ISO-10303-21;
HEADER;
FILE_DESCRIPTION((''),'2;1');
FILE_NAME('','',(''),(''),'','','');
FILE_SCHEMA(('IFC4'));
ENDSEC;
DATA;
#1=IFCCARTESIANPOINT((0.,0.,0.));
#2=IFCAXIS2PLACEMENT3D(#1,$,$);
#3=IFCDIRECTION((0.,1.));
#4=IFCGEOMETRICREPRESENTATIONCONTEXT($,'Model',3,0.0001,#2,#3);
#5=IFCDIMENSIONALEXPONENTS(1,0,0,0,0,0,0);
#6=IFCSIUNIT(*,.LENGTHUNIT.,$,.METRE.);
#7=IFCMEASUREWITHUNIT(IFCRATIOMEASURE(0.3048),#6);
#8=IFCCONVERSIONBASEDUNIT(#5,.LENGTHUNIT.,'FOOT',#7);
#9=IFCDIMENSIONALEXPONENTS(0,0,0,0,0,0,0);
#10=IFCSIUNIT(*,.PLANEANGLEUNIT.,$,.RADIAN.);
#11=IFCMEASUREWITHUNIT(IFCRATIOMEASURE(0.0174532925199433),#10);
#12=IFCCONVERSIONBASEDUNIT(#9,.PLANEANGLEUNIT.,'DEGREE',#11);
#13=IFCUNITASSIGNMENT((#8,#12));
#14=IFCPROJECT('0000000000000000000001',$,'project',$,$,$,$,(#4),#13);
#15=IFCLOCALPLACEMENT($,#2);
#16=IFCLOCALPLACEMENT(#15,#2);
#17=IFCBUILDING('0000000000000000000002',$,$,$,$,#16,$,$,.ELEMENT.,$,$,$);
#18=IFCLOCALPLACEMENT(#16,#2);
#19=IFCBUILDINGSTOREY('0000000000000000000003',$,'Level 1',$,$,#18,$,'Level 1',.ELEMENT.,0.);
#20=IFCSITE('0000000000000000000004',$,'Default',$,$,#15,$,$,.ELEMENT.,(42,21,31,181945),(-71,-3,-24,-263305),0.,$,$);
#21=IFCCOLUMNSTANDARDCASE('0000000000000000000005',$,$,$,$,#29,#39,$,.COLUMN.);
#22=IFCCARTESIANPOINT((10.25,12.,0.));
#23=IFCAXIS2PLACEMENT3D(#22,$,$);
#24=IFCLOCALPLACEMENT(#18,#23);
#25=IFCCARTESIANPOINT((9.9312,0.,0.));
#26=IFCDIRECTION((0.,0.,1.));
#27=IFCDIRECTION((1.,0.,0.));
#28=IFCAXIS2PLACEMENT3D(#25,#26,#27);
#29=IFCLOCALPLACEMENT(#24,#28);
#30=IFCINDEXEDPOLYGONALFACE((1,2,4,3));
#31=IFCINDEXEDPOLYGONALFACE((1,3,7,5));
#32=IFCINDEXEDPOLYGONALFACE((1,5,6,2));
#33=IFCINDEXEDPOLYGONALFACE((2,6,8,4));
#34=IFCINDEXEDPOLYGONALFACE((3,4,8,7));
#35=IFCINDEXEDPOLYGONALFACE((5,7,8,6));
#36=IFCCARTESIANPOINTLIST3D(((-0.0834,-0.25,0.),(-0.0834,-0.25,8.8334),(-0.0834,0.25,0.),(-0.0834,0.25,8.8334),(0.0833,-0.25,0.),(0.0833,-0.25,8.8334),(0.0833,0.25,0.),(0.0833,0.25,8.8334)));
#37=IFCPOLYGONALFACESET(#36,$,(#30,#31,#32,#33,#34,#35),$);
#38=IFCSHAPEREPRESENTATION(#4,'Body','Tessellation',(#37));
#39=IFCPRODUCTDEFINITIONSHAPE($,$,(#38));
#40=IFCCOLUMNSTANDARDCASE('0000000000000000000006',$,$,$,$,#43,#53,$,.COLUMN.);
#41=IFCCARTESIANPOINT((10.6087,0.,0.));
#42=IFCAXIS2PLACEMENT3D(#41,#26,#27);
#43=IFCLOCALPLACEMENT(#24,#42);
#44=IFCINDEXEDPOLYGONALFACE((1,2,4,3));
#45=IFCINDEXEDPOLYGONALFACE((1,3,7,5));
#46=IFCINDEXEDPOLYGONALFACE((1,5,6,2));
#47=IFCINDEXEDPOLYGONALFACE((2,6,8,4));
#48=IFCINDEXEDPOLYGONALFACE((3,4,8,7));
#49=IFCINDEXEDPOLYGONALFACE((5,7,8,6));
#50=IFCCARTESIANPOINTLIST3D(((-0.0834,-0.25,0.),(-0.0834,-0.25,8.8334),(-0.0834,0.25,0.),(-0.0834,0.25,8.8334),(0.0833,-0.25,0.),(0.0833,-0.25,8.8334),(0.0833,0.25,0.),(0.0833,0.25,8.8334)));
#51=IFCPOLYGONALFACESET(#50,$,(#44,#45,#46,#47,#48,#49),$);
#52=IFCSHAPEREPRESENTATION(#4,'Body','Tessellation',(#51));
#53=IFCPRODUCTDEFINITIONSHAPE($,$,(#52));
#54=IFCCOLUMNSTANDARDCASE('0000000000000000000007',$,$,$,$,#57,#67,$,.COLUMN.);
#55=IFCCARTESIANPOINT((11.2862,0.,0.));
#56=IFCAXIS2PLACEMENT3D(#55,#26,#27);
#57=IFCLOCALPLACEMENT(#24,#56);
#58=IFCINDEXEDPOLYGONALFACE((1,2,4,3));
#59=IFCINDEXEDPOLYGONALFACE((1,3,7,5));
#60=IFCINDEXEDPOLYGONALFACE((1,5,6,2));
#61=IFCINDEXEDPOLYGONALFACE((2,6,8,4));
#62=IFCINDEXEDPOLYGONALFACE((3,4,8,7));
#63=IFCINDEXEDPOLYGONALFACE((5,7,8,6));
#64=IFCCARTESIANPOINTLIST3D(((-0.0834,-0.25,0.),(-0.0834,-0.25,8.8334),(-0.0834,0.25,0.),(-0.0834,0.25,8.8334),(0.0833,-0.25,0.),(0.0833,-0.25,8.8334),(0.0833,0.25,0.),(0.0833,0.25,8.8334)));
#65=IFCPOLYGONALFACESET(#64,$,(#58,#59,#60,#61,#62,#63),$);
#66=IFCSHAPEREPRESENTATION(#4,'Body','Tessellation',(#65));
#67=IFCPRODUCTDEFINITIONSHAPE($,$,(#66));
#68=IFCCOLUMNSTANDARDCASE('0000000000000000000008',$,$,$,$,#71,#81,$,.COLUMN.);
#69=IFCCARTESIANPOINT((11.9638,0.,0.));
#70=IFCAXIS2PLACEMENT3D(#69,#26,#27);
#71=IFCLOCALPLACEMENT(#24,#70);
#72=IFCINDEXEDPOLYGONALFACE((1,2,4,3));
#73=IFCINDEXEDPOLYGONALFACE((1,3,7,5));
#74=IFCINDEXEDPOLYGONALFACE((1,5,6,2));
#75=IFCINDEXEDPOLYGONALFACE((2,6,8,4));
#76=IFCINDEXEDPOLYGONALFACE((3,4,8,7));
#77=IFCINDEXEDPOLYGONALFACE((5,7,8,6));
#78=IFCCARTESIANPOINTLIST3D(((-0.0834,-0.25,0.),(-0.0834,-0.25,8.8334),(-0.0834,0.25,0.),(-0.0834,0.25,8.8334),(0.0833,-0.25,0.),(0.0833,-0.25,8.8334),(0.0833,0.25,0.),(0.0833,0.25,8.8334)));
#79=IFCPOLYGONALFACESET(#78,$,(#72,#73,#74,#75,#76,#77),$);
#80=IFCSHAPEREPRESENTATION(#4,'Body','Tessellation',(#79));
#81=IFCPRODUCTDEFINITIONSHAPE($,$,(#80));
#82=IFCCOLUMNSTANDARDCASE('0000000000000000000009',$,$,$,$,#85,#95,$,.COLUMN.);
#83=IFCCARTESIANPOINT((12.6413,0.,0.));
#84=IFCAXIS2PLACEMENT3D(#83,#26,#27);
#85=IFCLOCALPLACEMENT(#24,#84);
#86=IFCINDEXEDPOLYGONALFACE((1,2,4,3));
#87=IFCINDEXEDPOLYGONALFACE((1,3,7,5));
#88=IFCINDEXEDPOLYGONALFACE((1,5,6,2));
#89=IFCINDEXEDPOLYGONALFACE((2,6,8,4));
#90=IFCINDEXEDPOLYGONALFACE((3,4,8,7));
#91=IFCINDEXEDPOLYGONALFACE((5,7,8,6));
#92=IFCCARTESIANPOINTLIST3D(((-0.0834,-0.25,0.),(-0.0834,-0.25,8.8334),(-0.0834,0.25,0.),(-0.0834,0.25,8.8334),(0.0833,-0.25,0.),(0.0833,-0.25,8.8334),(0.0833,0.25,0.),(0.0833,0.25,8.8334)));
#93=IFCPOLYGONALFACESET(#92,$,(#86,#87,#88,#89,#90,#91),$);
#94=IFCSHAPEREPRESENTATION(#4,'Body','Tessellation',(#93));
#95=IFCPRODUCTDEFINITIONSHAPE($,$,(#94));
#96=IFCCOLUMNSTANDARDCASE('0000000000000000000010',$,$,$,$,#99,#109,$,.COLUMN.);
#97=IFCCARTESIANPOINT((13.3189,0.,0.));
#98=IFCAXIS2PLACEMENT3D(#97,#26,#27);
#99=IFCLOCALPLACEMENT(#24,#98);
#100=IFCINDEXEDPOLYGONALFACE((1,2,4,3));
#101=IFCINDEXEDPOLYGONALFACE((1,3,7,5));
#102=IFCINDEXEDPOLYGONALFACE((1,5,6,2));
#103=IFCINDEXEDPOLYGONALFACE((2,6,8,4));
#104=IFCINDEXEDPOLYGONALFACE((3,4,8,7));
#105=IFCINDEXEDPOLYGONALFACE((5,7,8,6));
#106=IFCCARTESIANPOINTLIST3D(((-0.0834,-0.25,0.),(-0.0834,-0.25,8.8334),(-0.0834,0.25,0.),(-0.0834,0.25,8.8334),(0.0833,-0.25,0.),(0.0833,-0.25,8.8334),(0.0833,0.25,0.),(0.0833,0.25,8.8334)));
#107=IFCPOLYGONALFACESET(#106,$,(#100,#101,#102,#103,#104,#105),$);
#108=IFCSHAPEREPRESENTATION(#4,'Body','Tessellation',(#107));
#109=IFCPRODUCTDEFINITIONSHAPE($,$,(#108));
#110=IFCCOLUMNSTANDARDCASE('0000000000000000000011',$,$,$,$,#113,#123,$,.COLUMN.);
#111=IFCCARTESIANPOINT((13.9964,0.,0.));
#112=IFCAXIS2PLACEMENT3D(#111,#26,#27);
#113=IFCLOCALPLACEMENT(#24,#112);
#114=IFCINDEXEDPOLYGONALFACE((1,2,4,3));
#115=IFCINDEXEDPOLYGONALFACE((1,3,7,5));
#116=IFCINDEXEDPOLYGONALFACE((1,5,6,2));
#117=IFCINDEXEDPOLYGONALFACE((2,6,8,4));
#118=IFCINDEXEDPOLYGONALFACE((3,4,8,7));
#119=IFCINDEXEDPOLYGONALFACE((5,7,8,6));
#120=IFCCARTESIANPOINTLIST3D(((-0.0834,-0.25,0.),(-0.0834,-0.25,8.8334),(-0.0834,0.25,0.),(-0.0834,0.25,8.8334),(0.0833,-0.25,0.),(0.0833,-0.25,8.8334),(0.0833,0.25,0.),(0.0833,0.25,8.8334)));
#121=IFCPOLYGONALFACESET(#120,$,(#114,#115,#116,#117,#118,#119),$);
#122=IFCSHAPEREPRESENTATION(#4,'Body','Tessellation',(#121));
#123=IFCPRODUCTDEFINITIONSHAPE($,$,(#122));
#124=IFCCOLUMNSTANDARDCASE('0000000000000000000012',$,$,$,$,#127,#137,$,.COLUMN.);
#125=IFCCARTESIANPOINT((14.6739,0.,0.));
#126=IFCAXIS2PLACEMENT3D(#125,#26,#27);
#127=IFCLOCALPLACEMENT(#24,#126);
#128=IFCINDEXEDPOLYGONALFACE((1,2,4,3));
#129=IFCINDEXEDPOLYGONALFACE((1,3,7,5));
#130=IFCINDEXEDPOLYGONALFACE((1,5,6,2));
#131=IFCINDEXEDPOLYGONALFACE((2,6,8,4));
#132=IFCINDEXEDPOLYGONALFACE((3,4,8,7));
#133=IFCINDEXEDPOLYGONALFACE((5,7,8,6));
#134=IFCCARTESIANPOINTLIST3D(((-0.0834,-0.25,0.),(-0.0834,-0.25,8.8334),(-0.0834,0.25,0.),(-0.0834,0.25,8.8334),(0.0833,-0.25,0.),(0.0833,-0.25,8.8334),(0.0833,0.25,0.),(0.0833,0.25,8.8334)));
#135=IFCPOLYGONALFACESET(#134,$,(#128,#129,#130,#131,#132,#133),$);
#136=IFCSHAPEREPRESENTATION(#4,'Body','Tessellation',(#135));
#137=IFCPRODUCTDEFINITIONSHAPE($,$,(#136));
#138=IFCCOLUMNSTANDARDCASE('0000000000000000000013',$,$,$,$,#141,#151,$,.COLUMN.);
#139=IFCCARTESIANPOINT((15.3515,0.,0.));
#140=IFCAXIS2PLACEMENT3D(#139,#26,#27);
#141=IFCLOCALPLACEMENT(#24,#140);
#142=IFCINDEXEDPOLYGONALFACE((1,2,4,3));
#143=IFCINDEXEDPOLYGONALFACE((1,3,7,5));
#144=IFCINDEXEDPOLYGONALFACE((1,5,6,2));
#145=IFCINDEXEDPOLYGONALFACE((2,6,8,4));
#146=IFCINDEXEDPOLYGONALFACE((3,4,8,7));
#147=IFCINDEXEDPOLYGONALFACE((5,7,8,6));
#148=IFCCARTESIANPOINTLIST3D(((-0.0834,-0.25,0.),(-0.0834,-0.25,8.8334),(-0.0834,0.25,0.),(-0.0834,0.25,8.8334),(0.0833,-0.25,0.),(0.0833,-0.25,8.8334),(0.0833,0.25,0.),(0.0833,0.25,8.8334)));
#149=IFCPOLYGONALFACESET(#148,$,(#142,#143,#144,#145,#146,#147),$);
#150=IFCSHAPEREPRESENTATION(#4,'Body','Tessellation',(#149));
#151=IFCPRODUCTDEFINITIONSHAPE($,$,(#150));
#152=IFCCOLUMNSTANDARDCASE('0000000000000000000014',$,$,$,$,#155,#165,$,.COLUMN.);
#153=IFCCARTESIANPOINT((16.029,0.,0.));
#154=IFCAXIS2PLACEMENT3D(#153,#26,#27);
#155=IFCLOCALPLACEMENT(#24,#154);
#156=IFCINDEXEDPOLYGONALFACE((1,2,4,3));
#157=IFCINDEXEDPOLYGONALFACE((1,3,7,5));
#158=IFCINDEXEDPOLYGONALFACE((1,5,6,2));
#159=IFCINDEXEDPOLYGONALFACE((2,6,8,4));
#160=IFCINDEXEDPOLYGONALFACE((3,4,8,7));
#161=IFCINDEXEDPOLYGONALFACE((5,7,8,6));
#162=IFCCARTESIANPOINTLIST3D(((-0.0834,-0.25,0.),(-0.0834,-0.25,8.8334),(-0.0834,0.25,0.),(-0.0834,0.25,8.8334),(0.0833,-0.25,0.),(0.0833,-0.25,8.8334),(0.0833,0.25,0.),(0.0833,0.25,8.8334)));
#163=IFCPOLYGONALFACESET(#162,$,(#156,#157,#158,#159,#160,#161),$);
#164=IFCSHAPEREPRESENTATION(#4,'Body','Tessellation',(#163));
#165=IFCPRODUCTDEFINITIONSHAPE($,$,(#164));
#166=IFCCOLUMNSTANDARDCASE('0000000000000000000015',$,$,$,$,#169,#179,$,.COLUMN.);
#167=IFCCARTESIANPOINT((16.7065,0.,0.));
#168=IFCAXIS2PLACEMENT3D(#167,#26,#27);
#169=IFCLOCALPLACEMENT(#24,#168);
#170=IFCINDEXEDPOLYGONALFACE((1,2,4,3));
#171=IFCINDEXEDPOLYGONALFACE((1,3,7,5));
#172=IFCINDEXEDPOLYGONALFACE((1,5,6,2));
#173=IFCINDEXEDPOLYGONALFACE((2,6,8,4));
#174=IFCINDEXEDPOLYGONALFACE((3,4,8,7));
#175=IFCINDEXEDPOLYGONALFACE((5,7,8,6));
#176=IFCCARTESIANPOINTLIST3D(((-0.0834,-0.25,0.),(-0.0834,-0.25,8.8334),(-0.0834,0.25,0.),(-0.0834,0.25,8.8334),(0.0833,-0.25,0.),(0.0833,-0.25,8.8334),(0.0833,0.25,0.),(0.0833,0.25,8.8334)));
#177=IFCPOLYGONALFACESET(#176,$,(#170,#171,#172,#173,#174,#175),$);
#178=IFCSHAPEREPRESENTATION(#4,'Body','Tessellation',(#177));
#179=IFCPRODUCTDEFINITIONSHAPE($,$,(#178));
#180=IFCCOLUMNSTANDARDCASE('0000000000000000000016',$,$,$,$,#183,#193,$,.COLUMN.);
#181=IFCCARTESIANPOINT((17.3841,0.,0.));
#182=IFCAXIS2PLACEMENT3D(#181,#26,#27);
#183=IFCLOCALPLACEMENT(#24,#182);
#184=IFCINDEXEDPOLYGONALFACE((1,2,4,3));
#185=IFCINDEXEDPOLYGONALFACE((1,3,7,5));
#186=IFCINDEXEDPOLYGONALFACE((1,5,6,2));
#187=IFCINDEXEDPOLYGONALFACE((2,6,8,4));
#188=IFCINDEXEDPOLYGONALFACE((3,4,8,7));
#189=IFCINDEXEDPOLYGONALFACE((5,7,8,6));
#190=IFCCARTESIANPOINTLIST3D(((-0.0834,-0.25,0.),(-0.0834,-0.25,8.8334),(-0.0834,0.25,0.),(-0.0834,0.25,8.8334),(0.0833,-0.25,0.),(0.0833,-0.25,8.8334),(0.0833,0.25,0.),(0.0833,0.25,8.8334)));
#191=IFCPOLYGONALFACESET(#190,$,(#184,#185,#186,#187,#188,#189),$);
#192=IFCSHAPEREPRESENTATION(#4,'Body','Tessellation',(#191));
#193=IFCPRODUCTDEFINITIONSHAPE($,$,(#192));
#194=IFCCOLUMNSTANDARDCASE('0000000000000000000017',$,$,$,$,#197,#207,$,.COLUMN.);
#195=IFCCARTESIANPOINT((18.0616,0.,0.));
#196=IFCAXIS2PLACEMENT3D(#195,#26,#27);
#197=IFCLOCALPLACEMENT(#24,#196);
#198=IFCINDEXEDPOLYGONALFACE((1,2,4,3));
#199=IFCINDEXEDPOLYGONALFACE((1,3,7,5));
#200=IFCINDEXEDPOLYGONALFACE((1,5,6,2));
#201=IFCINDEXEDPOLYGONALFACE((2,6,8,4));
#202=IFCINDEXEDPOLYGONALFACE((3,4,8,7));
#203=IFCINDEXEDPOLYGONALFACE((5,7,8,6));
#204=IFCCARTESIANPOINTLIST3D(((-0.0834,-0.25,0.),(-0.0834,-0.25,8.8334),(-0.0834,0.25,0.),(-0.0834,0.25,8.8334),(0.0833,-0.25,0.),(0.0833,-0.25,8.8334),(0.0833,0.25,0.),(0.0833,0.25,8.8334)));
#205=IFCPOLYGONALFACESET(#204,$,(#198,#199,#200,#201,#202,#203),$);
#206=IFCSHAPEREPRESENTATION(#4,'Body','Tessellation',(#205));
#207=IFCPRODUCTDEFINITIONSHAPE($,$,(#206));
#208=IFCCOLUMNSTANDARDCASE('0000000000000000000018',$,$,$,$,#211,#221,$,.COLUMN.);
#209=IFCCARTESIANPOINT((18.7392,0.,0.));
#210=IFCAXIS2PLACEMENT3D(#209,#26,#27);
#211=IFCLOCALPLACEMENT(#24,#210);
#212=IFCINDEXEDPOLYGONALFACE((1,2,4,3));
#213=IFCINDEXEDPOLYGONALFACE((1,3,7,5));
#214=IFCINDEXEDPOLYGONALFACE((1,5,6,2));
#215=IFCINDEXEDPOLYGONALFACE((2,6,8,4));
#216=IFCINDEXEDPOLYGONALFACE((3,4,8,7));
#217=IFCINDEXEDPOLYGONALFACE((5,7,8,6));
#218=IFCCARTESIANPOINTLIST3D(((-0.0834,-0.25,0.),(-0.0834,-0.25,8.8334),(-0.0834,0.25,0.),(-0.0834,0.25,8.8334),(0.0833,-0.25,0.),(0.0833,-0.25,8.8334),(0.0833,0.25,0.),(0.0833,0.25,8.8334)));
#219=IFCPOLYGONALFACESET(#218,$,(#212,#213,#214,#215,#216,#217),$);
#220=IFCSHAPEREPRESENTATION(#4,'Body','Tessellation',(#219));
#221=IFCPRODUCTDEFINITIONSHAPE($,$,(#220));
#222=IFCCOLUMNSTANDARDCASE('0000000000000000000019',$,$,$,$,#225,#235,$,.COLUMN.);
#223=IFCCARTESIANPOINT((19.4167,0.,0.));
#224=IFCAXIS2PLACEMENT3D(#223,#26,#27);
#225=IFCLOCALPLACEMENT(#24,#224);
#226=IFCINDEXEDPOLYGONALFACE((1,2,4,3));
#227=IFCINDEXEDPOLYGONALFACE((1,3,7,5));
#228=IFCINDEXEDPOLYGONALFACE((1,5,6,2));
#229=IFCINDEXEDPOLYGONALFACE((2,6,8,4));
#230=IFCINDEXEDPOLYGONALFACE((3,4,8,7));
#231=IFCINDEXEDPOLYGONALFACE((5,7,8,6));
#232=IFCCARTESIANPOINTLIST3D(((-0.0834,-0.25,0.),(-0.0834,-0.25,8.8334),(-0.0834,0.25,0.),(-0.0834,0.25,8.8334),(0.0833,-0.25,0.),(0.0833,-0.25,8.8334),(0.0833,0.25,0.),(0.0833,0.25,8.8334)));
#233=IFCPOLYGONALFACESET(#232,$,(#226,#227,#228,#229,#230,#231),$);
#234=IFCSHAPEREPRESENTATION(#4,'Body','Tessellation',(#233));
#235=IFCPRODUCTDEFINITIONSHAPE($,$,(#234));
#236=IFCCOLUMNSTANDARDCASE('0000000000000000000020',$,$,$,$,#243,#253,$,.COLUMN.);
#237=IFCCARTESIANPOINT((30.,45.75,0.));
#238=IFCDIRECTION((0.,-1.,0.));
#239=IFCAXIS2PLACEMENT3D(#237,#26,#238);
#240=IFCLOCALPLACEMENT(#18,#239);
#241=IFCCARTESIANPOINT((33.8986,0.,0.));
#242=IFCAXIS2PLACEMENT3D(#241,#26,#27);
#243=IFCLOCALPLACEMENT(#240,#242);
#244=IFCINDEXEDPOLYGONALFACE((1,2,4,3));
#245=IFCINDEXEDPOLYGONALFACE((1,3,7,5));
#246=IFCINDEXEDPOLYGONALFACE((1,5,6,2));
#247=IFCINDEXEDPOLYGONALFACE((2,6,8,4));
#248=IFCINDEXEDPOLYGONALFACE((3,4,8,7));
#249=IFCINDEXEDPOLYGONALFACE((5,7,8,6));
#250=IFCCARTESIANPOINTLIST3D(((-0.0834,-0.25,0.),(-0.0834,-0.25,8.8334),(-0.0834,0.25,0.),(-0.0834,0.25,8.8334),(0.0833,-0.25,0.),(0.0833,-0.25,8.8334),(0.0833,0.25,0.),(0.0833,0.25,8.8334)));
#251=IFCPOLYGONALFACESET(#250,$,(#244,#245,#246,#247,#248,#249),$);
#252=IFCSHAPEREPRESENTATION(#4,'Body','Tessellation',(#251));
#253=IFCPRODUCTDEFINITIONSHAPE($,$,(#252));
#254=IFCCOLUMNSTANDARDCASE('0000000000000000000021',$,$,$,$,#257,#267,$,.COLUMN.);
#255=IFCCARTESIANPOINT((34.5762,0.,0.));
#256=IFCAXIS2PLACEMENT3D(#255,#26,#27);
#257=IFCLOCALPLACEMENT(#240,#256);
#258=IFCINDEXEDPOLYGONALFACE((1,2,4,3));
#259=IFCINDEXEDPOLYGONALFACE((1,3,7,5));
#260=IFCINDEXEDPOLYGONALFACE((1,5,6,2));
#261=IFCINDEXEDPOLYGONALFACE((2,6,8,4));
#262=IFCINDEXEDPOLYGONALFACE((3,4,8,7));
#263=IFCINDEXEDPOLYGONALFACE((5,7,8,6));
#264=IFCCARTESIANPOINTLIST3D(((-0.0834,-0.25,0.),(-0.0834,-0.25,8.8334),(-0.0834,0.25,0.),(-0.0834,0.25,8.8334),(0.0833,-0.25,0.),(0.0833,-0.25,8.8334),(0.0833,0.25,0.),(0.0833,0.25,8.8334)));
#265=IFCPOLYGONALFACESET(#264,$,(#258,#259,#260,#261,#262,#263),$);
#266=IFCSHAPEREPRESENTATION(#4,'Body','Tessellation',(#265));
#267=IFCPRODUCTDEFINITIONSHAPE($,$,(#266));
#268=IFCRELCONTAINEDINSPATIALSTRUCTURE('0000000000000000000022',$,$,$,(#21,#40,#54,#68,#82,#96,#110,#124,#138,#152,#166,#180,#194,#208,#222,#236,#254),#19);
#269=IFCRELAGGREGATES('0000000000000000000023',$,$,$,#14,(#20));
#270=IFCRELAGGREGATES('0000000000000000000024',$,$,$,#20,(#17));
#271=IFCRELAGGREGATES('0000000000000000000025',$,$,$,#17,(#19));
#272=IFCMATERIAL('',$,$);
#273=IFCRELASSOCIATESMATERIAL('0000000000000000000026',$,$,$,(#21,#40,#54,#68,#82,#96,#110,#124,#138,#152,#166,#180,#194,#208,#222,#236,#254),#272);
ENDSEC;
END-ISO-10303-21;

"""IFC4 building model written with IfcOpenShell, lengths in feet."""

from ifc_helpers import new_model, entity, si_unit, converted_unit, direction, frame, origin, place, context, project, spatial, rectangle, extrude, material, element, save


model = new_model("IFC4")

# Units and contexts
model_context = context("Model", 3, precision=0.0001, world=origin(), true_north=direction((0.0, 1.0)))
ifc_project = project(units=[converted_unit("LENGTHUNIT", "FOOT", entity("IfcRatioMeasure", 0.3048), si_unit("LENGTHUNIT", "METRE"), dimensions=[1, 0, 0, 0, 0, 0, 0]), converted_unit("PLANEANGLEUNIT", "DEGREE", entity("IfcRatioMeasure", 0.0174532925199433), si_unit("PLANEANGLEUNIT", "RADIAN"), dimensions=[0, 0, 0, 0, 0, 0, 0])], contexts=[model_context])

# Site, building, storey
site_placement = place(None, origin())
site = spatial("IfcSite", under=ifc_project, at=site_placement, Name="Default", CompositionType="ELEMENT", RefLatitude=(42, 21, 31, 181945), RefLongitude=(-71, -3, -24, -263305), RefElevation=0.0)
building_placement = place(site_placement, origin())
building = spatial("IfcBuilding", under=site, at=building_placement, CompositionType="ELEMENT")
storey_placement = place(building_placement, origin())
storey = spatial("IfcBuildingStorey", under=building, at=storey_placement, Name="Level 1", LongName="Level 1", CompositionType="ELEMENT", Elevation=0.0)

# Columns
ifc_material_1 = material(Name="")
placement_1 = place(storey_placement, frame((10.25, 12.0, 0.0)))
for number, where, z_axis, x_axis in (
    (1, (9.9312, 0.0, 0.0), (0.0, 0.0, 1.0), (1.0, 0.0, 0.0)),
    (2, (10.6087, 0.0, 0.0), (0.0, 0.0, 1.0), (1.0, 0.0, 0.0)),
    (3, (11.2862, 0.0, 0.0), (0.0, 0.0, 1.0), (1.0, 0.0, 0.0)),
    (4, (11.9638, 0.0, 0.0), (0.0, 0.0, 1.0), (1.0, 0.0, 0.0)),
    (5, (12.6413, 0.0, 0.0), (0.0, 0.0, 1.0), (1.0, 0.0, 0.0)),
    (6, (13.3189, 0.0, 0.0), (0.0, 0.0, 1.0), (1.0, 0.0, 0.0)),
    (7, (13.9964, 0.0, 0.0), (0.0, 0.0, 1.0), (1.0, 0.0, 0.0)),
    (8, (14.6739, 0.0, 0.0), (0.0, 0.0, 1.0), (1.0, 0.0, 0.0)),
    (9, (15.3515, 0.0, 0.0), (0.0, 0.0, 1.0), (1.0, 0.0, 0.0)),
    (10, (16.029, 0.0, 0.0), (0.0, 0.0, 1.0), (1.0, 0.0, 0.0)),
    (11, (16.7065, 0.0, 0.0), (0.0, 0.0, 1.0), (1.0, 0.0, 0.0)),
    (12, (17.3841, 0.0, 0.0), (0.0, 0.0, 1.0), (1.0, 0.0, 0.0)),
    (13, (18.0616, 0.0, 0.0), (0.0, 0.0, 1.0), (1.0, 0.0, 0.0)),
    (14, (18.7392, 0.0, 0.0), (0.0, 0.0, 1.0), (1.0, 0.0, 0.0)),
    (15, (19.4167, 0.0, 0.0), (0.0, 0.0, 1.0), (1.0, 0.0, 0.0)),
):
    element("IfcColumnStandardCase", number, at=place(placement_1, frame(where, z_axis=z_axis, x_axis=x_axis)), inside=storey, material=ifc_material_1, PredefinedType="COLUMN", context=model_context, shape_type="SweptSolid", body=[
        extrude(rectangle(XDim=0.1667, YDim=0.5), origin(), (0.0, 0.0, 1.0), 8.8334),
    ])
placement_2 = place(storey_placement, frame((30.0, 45.75, 0.0), z_axis=(0.0, 0.0, 1.0), x_axis=(0.0, -1.0, 0.0)))
for number, where, z_axis, x_axis in (
    (16, (33.8986, 0.0, 0.0), (0.0, 0.0, 1.0), (1.0, 0.0, 0.0)),
    (17, (34.5762, 0.0, 0.0), (0.0, 0.0, 1.0), (1.0, 0.0, 0.0)),
):
    element("IfcColumnStandardCase", number, at=place(placement_2, frame(where, z_axis=z_axis, x_axis=x_axis)), inside=storey, material=ifc_material_1, PredefinedType="COLUMN", context=model_context, shape_type="SweptSolid", body=[
        extrude(rectangle(XDim=0.1667, YDim=0.5), origin(), (0.0, 0.0, 1.0), 8.8334),
    ])

save(model, "model.ifc")
